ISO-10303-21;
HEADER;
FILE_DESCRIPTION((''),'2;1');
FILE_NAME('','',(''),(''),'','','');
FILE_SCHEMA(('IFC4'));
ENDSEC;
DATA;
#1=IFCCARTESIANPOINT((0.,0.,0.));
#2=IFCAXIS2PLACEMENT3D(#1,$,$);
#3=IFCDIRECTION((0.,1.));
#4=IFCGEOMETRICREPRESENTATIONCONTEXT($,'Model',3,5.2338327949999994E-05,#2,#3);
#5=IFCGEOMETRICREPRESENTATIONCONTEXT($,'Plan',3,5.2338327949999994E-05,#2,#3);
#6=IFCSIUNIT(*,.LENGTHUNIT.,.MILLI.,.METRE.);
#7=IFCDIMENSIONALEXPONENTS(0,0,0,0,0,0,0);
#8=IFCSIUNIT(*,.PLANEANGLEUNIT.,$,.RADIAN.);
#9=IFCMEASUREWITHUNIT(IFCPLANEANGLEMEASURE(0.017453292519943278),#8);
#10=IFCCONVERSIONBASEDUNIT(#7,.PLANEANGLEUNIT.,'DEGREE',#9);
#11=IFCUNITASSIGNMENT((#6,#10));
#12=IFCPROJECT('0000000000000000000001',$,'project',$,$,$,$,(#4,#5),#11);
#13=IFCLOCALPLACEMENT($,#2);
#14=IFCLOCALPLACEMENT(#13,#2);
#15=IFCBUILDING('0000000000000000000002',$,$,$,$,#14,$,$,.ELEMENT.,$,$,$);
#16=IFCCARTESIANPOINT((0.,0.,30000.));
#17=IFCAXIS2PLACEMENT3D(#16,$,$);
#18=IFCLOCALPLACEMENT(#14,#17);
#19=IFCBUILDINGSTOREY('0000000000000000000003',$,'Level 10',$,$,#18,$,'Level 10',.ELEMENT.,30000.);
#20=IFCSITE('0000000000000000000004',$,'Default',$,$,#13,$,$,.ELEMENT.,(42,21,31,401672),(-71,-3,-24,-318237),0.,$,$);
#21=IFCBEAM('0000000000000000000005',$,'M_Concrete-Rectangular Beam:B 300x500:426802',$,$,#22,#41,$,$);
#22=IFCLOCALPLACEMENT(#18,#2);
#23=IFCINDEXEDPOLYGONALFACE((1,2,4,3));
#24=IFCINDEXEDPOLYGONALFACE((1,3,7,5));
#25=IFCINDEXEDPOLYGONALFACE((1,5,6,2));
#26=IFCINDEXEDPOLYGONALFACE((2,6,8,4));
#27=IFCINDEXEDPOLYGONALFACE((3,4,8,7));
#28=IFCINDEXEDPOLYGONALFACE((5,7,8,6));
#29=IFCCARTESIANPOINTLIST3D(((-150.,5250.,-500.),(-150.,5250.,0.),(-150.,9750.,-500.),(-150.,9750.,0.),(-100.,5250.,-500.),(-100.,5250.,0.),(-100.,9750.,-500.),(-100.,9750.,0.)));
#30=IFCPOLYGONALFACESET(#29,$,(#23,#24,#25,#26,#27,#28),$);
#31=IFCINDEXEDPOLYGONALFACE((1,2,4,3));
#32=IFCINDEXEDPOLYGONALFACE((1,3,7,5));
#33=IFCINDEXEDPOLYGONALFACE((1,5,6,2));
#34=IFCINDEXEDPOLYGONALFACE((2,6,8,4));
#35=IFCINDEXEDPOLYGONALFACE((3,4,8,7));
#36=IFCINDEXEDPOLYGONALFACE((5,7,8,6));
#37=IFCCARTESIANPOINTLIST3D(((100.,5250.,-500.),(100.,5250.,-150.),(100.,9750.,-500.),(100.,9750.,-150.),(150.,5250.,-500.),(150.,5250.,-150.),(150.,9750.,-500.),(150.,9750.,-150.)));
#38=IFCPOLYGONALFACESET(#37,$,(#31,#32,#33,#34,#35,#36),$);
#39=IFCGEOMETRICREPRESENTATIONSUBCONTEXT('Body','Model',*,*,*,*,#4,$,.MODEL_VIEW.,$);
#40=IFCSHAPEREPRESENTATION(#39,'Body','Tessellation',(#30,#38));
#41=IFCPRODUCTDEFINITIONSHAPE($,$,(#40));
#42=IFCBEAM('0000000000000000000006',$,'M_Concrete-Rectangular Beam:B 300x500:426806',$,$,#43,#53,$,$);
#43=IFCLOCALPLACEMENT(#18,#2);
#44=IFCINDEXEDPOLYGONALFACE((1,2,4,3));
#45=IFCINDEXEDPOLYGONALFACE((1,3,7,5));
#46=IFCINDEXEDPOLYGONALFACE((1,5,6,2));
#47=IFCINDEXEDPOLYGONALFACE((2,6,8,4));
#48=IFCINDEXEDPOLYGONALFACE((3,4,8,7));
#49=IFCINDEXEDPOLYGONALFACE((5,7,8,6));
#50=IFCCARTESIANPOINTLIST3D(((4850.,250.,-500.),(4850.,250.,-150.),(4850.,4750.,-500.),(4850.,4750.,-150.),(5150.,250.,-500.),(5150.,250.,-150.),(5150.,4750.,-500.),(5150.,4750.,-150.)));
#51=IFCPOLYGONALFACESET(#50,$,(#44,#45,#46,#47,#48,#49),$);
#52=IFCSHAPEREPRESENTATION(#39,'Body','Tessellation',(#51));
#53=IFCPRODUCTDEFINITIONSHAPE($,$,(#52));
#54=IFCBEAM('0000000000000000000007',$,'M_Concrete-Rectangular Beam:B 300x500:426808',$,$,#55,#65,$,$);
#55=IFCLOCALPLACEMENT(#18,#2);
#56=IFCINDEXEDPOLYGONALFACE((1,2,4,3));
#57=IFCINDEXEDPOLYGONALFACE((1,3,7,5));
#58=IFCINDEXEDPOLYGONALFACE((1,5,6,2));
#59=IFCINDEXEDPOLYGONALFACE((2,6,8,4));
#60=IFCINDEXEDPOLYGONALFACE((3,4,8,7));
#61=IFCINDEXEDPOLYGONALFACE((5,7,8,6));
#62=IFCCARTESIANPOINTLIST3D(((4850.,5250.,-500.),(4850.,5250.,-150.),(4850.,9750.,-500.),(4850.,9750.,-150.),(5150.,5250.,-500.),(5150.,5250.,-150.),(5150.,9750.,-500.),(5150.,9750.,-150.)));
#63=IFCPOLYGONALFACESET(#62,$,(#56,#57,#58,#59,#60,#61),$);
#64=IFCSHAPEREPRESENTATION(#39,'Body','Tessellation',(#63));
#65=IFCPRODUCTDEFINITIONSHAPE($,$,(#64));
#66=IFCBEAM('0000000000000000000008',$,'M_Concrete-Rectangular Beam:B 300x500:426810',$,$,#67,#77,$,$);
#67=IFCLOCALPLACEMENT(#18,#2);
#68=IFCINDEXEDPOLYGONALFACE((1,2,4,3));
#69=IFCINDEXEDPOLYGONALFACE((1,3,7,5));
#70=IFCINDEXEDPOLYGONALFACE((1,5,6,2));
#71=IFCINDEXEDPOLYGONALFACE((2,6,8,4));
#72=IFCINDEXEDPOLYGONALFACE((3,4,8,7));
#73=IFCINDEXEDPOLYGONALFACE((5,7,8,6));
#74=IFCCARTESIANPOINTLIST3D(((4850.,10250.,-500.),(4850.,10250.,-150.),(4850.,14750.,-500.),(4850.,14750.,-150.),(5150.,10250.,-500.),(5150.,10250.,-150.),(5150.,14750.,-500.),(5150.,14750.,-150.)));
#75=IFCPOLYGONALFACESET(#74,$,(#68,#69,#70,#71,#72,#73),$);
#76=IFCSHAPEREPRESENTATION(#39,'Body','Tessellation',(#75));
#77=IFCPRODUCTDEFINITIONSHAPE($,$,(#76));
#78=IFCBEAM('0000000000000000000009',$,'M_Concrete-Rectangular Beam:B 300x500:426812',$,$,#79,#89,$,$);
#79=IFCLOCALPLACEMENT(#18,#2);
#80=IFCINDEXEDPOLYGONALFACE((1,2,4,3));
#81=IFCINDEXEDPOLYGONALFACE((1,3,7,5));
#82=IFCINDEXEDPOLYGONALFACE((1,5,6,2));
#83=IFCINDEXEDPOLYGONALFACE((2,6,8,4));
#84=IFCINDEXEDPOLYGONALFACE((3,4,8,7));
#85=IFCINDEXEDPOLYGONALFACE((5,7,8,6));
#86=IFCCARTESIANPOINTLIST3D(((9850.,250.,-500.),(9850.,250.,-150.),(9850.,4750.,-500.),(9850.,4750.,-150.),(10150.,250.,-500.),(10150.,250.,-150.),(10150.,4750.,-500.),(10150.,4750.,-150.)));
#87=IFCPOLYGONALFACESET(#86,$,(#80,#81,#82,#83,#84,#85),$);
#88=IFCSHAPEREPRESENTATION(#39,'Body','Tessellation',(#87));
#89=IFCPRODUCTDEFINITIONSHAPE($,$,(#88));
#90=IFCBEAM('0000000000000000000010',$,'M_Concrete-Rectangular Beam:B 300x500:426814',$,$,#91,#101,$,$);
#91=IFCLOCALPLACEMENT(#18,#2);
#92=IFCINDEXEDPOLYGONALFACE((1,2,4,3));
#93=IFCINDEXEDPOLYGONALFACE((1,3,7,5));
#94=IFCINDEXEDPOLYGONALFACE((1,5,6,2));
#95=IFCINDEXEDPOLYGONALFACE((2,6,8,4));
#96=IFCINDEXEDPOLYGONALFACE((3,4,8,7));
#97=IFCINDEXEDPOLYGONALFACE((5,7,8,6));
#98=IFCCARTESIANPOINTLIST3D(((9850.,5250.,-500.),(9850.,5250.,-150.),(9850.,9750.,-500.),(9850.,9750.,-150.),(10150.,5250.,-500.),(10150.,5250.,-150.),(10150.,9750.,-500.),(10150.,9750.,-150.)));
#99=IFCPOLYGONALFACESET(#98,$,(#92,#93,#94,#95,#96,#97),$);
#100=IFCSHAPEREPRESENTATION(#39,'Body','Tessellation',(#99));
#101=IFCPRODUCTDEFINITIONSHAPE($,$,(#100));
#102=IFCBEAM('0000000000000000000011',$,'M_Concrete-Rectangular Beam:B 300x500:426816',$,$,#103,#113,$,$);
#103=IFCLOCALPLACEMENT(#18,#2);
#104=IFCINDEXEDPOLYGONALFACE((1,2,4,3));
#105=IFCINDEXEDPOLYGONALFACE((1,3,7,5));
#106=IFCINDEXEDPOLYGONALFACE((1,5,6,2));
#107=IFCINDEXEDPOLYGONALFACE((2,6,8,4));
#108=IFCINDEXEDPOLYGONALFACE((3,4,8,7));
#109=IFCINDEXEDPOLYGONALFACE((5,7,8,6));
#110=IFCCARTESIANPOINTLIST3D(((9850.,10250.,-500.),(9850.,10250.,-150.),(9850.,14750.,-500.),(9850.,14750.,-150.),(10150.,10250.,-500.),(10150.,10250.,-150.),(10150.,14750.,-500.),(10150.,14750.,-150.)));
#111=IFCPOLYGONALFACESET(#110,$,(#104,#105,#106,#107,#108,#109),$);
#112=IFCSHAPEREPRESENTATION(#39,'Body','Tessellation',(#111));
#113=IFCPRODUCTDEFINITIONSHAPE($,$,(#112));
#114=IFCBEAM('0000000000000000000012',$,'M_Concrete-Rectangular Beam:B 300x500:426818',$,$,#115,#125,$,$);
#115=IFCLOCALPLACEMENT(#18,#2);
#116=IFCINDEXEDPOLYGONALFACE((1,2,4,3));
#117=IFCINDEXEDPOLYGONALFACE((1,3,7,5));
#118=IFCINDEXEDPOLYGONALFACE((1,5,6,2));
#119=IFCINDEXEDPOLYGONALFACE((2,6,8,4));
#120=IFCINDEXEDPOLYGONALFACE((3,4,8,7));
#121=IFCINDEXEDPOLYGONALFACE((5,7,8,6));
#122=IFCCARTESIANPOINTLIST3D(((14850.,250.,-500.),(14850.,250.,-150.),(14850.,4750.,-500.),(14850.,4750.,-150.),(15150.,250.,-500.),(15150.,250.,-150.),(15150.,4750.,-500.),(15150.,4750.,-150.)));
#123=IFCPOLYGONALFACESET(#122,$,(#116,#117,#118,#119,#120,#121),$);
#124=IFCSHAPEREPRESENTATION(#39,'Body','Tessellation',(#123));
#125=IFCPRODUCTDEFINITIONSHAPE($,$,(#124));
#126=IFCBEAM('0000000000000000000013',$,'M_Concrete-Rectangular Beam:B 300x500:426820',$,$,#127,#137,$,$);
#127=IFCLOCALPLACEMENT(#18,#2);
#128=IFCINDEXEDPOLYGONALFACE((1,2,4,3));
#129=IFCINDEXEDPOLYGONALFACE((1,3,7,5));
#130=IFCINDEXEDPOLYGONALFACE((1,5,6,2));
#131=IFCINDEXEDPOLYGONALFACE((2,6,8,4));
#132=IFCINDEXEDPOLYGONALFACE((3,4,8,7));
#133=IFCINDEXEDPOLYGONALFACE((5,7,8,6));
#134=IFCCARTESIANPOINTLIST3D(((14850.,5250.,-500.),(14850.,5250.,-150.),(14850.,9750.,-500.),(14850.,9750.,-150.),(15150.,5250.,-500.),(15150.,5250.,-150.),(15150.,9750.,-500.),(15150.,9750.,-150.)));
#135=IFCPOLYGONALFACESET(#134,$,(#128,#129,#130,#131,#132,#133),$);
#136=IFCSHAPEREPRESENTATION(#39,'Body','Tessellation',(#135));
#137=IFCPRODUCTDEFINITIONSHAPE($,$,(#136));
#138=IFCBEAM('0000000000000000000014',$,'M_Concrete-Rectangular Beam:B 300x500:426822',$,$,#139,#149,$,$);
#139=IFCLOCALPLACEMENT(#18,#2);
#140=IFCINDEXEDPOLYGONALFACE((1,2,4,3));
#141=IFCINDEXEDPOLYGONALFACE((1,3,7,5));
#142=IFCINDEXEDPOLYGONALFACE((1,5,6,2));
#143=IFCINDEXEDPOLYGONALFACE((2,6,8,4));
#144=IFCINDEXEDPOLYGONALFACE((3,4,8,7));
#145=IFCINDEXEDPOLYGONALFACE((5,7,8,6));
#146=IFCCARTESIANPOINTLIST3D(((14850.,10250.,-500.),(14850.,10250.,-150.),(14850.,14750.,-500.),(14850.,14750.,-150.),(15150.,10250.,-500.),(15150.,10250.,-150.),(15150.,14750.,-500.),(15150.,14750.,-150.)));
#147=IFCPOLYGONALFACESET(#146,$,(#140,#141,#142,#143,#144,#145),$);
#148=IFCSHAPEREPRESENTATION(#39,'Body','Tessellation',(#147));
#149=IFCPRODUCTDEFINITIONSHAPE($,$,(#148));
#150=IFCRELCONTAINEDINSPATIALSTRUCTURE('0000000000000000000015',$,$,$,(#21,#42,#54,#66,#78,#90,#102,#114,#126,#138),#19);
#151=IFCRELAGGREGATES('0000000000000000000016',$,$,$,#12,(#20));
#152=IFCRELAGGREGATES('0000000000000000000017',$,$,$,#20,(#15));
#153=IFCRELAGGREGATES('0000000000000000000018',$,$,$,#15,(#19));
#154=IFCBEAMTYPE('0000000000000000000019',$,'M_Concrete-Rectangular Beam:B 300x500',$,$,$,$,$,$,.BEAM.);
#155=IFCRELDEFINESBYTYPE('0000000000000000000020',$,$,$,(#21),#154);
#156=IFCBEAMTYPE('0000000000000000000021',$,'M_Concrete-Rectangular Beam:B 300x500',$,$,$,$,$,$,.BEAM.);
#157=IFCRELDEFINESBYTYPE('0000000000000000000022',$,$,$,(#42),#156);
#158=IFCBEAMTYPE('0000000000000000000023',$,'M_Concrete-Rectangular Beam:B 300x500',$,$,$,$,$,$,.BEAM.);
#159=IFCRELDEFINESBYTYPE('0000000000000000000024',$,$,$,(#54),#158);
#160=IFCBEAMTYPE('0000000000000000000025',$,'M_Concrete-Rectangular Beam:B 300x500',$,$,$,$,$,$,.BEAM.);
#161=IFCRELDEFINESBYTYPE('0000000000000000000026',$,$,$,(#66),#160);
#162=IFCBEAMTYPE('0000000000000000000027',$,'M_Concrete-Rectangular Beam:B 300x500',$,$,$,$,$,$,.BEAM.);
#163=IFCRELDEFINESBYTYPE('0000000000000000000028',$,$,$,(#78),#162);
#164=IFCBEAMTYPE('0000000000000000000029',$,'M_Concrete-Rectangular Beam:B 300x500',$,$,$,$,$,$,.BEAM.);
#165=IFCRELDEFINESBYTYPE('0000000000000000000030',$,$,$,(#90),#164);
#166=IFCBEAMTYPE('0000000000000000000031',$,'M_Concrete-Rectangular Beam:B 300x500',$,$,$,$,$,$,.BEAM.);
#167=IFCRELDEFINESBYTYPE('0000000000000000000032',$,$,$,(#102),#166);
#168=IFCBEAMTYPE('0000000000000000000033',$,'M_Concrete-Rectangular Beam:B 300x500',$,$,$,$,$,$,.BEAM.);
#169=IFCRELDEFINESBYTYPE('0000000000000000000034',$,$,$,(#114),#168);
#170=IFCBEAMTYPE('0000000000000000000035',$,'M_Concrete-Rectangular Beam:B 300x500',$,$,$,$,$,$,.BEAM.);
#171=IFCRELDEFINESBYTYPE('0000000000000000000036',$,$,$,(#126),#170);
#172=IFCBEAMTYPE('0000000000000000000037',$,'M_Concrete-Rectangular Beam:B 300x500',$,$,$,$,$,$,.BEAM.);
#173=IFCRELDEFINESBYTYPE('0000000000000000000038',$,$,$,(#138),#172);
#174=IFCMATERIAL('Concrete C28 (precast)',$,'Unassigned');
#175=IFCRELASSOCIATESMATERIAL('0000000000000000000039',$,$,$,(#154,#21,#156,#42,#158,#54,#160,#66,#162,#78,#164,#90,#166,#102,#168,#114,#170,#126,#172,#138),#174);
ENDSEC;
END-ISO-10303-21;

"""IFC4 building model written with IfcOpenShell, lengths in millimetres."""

from ifc_helpers import new_model, entity, si_unit, converted_unit, direction, frame, origin, place, context, subcontext, project, spatial, indexed_curve, outline, extrude, source, transform, mapped, material, type_object, type_shapes, element, save


model = new_model("IFC4")

# Units and contexts
model_context = context("Model", 3, precision=5.2338327949999994e-05, world=origin(), true_north=direction((0.0, 1.0)))
plan_context = context("Plan", 3, precision=5.2338327949999994e-05, world=origin(), true_north=direction((0.0, 1.0)))
body_context = subcontext(model_context, "Body", "Model", "MODEL_VIEW")
ifc_project = project(units=[si_unit("LENGTHUNIT", "METRE", prefix="MILLI"), converted_unit("PLANEANGLEUNIT", "DEGREE", entity("IfcPlaneAngleMeasure", 0.017453292519943278), si_unit("PLANEANGLEUNIT", "RADIAN"), dimensions=[0, 0, 0, 0, 0, 0, 0])], contexts=[model_context, plan_context])

# Site, building, storey
site_placement = place(None, origin())
site = spatial("IfcSite", under=ifc_project, at=site_placement, Name="Default", CompositionType="ELEMENT", RefLatitude=(42, 21, 31, 401672), RefLongitude=(-71, -3, -24, -318237), RefElevation=0.0)
building_placement = place(site_placement, origin())
building = spatial("IfcBuilding", under=site, at=building_placement, CompositionType="ELEMENT")
storey_placement = place(building_placement, frame((0.0, 0.0, 30000.0)))
storey = spatial("IfcBuildingStorey", under=building, at=storey_placement, Name="Level 10", LongName="Level 10", CompositionType="ELEMENT", Elevation=30000.0)

# Beams
ifc_material = material(Name="Concrete C28 (precast)", Category="Unassigned")
beam_type_1 = type_object("IfcBeamType", Name="M_Concrete-Rectangular Beam:B 300x500", PredefinedType="BEAM", material=ifc_material)
shared_shape_1 = source(origin(), body_context, "Body", "SweptSolid", [
    extrude(outline(indexed_curve([(-25.0, -250.0), (25.0, -250.0), (25.0, 250.0), (-25.0, 250.0), (-25.0, -250.0)], self_intersect=False)), frame((-125.0, 5250.0, 29750.0), z_axis=(0.0, 1.0, 0.0), x_axis=(-1.0, 0.0, 0.0)), (0.0, 0.0, 1.0), 4500.0),
    extrude(outline(indexed_curve([(-25.0, -175.0), (25.0, -175.0), (25.0, 175.0), (-25.0, 175.0), (-25.0, -175.0)], self_intersect=False)), frame((125.0, 5250.0, 29675.0), z_axis=(0.0, 1.0, 0.0), x_axis=(-1.0, 0.0, 0.0)), (0.0, 0.0, 1.0), 4500.0),
])
type_shapes(beam_type_1, [shared_shape_1])
beam_1_placement = place(storey_placement, frame((0.0, 0.0, -30000.0)))
element("IfcBeam", 1, at=beam_1_placement, inside=storey, type_object=beam_type_1, material=ifc_material, Name="M_Concrete-Rectangular Beam:B 300x500:426802", context=body_context, shape_type="MappedRepresentation", body=[
    mapped(shared_shape_1, transform((0.0, 0.0, 0.0), scale=1.0)),
])
beam_type_2 = type_object("IfcBeamType", Name="M_Concrete-Rectangular Beam:B 300x500", PredefinedType="BEAM", material=ifc_material)
shared_shape_2 = source(origin(), body_context, "Body", "SweptSolid", [
    extrude(outline(indexed_curve([(-150.0, -175.0), (150.0, -175.0), (150.0, 175.0), (-150.0, 175.0), (-150.0, -175.0)], self_intersect=False)), frame((5000.0, 250.0, 29675.0), z_axis=(0.0, 1.0, 0.0), x_axis=(-1.0, 0.0, 0.0)), (0.0, 0.0, 1.0), 4500.0),
])
type_shapes(beam_type_2, [shared_shape_2])
beam_2_placement = place(storey_placement, frame((0.0, 0.0, -30000.0)))
element("IfcBeam", 2, at=beam_2_placement, inside=storey, type_object=beam_type_2, material=ifc_material, Name="M_Concrete-Rectangular Beam:B 300x500:426806", context=body_context, shape_type="MappedRepresentation", body=[
    mapped(shared_shape_2, transform((0.0, 0.0, 0.0), scale=1.0)),
])
beam_type_3 = type_object("IfcBeamType", Name="M_Concrete-Rectangular Beam:B 300x500", PredefinedType="BEAM", material=ifc_material)
shared_shape_3 = source(origin(), body_context, "Body", "SweptSolid", [
    extrude(outline(indexed_curve([(-150.0, -175.0), (150.0, -175.0), (150.0, 175.0), (-150.0, 175.0), (-150.0, -175.0)], self_intersect=False)), frame((5000.0, 5250.0, 29675.0), z_axis=(0.0, 1.0, 0.0), x_axis=(-1.0, 0.0, 0.0)), (0.0, 0.0, 1.0), 4500.0),
])
type_shapes(beam_type_3, [shared_shape_3])
beam_3_placement = place(storey_placement, frame((0.0, 0.0, -30000.0)))
element("IfcBeam", 3, at=beam_3_placement, inside=storey, type_object=beam_type_3, material=ifc_material, Name="M_Concrete-Rectangular Beam:B 300x500:426808", context=body_context, shape_type="MappedRepresentation", body=[
    mapped(shared_shape_3, transform((0.0, 0.0, 0.0), scale=1.0)),
])
beam_type_4 = type_object("IfcBeamType", Name="M_Concrete-Rectangular Beam:B 300x500", PredefinedType="BEAM", material=ifc_material)
shared_shape_4 = source(origin(), body_context, "Body", "SweptSolid", [
    extrude(outline(indexed_curve([(-150.0, -175.0), (150.0, -175.0), (150.0, 175.0), (-150.0, 175.0), (-150.0, -175.0)], self_intersect=False)), frame((5000.0, 10250.0, 29675.0), z_axis=(0.0, 1.0, 0.0), x_axis=(-1.0, 0.0, 0.0)), (0.0, 0.0, 1.0), 4500.0),
])
type_shapes(beam_type_4, [shared_shape_4])
beam_4_placement = place(storey_placement, frame((0.0, 0.0, -30000.0)))
element("IfcBeam", 4, at=beam_4_placement, inside=storey, type_object=beam_type_4, material=ifc_material, Name="M_Concrete-Rectangular Beam:B 300x500:426810", context=body_context, shape_type="MappedRepresentation", body=[
    mapped(shared_shape_4, transform((0.0, 0.0, 0.0), scale=1.0)),
])
beam_type_5 = type_object("IfcBeamType", Name="M_Concrete-Rectangular Beam:B 300x500", PredefinedType="BEAM", material=ifc_material)
shared_shape_5 = source(origin(), body_context, "Body", "SweptSolid", [
    extrude(outline(indexed_curve([(-150.0, -175.0), (150.0, -175.0), (150.0, 175.0), (-150.0, 175.0), (-150.0, -175.0)], self_intersect=False)), frame((10000.0, 250.0, 29675.0), z_axis=(0.0, 1.0, 0.0), x_axis=(-1.0, 0.0, 0.0)), (0.0, 0.0, 1.0), 4500.0),
])
type_shapes(beam_type_5, [shared_shape_5])
beam_5_placement = place(storey_placement, frame((0.0, 0.0, -30000.0)))
element("IfcBeam", 5, at=beam_5_placement, inside=storey, type_object=beam_type_5, material=ifc_material, Name="M_Concrete-Rectangular Beam:B 300x500:426812", context=body_context, shape_type="MappedRepresentation", body=[
    mapped(shared_shape_5, transform((0.0, 0.0, 0.0), scale=1.0)),
])
beam_type_6 = type_object("IfcBeamType", Name="M_Concrete-Rectangular Beam:B 300x500", PredefinedType="BEAM", material=ifc_material)
shared_shape_6 = source(origin(), body_context, "Body", "SweptSolid", [
    extrude(outline(indexed_curve([(-150.0, -175.0), (150.0, -175.0), (150.0, 175.0), (-150.0, 175.0), (-150.0, -175.0)], self_intersect=False)), frame((10000.0, 5250.0, 29675.0), z_axis=(0.0, 1.0, 0.0), x_axis=(-1.0, 0.0, 0.0)), (0.0, 0.0, 1.0), 4500.0),
])
type_shapes(beam_type_6, [shared_shape_6])
beam_6_placement = place(storey_placement, frame((0.0, 0.0, -30000.0)))
element("IfcBeam", 6, at=beam_6_placement, inside=storey, type_object=beam_type_6, material=ifc_material, Name="M_Concrete-Rectangular Beam:B 300x500:426814", context=body_context, shape_type="MappedRepresentation", body=[
    mapped(shared_shape_6, transform((0.0, 0.0, 0.0), scale=1.0)),
])
beam_type_7 = type_object("IfcBeamType", Name="M_Concrete-Rectangular Beam:B 300x500", PredefinedType="BEAM", material=ifc_material)
shared_shape_7 = source(origin(), body_context, "Body", "SweptSolid", [
    extrude(outline(indexed_curve([(-150.0, -175.0), (150.0, -175.0), (150.0, 175.0), (-150.0, 175.0), (-150.0, -175.0)], self_intersect=False)), frame((10000.0, 10250.0, 29675.0), z_axis=(0.0, 1.0, 0.0), x_axis=(-1.0, 0.0, 0.0)), (0.0, 0.0, 1.0), 4500.0),
])
type_shapes(beam_type_7, [shared_shape_7])
beam_7_placement = place(storey_placement, frame((0.0, 0.0, -30000.0)))
element("IfcBeam", 7, at=beam_7_placement, inside=storey, type_object=beam_type_7, material=ifc_material, Name="M_Concrete-Rectangular Beam:B 300x500:426816", context=body_context, shape_type="MappedRepresentation", body=[
    mapped(shared_shape_7, transform((0.0, 0.0, 0.0), scale=1.0)),
])
beam_type_8 = type_object("IfcBeamType", Name="M_Concrete-Rectangular Beam:B 300x500", PredefinedType="BEAM", material=ifc_material)
shared_shape_8 = source(origin(), body_context, "Body", "SweptSolid", [
    extrude(outline(indexed_curve([(-150.0, -175.0), (150.0, -175.0), (150.0, 175.0), (-150.0, 175.0), (-150.0, -175.0)], self_intersect=False)), frame((15000.0, 250.0, 29675.0), z_axis=(0.0, 1.0, 0.0), x_axis=(-1.0, 0.0, 0.0)), (0.0, 0.0, 1.0), 4500.0),
])
type_shapes(beam_type_8, [shared_shape_8])
beam_8_placement = place(storey_placement, frame((0.0, 0.0, -30000.0)))
element("IfcBeam", 8, at=beam_8_placement, inside=storey, type_object=beam_type_8, material=ifc_material, Name="M_Concrete-Rectangular Beam:B 300x500:426818", context=body_context, shape_type="MappedRepresentation", body=[
    mapped(shared_shape_8, transform((0.0, 0.0, 0.0), scale=1.0)),
])
beam_type_9 = type_object("IfcBeamType", Name="M_Concrete-Rectangular Beam:B 300x500", PredefinedType="BEAM", material=ifc_material)
shared_shape_9 = source(origin(), body_context, "Body", "SweptSolid", [
    extrude(outline(indexed_curve([(-150.0, -175.0), (150.0, -175.0), (150.0, 175.0), (-150.0, 175.0), (-150.0, -175.0)], self_intersect=False)), frame((15000.0, 5250.0, 29675.0), z_axis=(0.0, 1.0, 0.0), x_axis=(-1.0, 0.0, 0.0)), (0.0, 0.0, 1.0), 4500.0),
])
type_shapes(beam_type_9, [shared_shape_9])
beam_9_placement = place(storey_placement, frame((0.0, 0.0, -30000.0)))
element("IfcBeam", 9, at=beam_9_placement, inside=storey, type_object=beam_type_9, material=ifc_material, Name="M_Concrete-Rectangular Beam:B 300x500:426820", context=body_context, shape_type="MappedRepresentation", body=[
    mapped(shared_shape_9, transform((0.0, 0.0, 0.0), scale=1.0)),
])
beam_type_10 = type_object("IfcBeamType", Name="M_Concrete-Rectangular Beam:B 300x500", PredefinedType="BEAM", material=ifc_material)
shared_shape_10 = source(origin(), body_context, "Body", "SweptSolid", [
    extrude(outline(indexed_curve([(-150.0, -175.0), (150.0, -175.0), (150.0, 175.0), (-150.0, 175.0), (-150.0, -175.0)], self_intersect=False)), frame((15000.0, 10250.0, 29675.0), z_axis=(0.0, 1.0, 0.0), x_axis=(-1.0, 0.0, 0.0)), (0.0, 0.0, 1.0), 4500.0),
])
type_shapes(beam_type_10, [shared_shape_10])
beam_10_placement = place(storey_placement, frame((0.0, 0.0, -30000.0)))
element("IfcBeam", 10, at=beam_10_placement, inside=storey, type_object=beam_type_10, material=ifc_material, Name="M_Concrete-Rectangular Beam:B 300x500:426822", context=body_context, shape_type="MappedRepresentation", body=[
    mapped(shared_shape_10, transform((0.0, 0.0, 0.0), scale=1.0)),
])

save(model, "model.ifc")
